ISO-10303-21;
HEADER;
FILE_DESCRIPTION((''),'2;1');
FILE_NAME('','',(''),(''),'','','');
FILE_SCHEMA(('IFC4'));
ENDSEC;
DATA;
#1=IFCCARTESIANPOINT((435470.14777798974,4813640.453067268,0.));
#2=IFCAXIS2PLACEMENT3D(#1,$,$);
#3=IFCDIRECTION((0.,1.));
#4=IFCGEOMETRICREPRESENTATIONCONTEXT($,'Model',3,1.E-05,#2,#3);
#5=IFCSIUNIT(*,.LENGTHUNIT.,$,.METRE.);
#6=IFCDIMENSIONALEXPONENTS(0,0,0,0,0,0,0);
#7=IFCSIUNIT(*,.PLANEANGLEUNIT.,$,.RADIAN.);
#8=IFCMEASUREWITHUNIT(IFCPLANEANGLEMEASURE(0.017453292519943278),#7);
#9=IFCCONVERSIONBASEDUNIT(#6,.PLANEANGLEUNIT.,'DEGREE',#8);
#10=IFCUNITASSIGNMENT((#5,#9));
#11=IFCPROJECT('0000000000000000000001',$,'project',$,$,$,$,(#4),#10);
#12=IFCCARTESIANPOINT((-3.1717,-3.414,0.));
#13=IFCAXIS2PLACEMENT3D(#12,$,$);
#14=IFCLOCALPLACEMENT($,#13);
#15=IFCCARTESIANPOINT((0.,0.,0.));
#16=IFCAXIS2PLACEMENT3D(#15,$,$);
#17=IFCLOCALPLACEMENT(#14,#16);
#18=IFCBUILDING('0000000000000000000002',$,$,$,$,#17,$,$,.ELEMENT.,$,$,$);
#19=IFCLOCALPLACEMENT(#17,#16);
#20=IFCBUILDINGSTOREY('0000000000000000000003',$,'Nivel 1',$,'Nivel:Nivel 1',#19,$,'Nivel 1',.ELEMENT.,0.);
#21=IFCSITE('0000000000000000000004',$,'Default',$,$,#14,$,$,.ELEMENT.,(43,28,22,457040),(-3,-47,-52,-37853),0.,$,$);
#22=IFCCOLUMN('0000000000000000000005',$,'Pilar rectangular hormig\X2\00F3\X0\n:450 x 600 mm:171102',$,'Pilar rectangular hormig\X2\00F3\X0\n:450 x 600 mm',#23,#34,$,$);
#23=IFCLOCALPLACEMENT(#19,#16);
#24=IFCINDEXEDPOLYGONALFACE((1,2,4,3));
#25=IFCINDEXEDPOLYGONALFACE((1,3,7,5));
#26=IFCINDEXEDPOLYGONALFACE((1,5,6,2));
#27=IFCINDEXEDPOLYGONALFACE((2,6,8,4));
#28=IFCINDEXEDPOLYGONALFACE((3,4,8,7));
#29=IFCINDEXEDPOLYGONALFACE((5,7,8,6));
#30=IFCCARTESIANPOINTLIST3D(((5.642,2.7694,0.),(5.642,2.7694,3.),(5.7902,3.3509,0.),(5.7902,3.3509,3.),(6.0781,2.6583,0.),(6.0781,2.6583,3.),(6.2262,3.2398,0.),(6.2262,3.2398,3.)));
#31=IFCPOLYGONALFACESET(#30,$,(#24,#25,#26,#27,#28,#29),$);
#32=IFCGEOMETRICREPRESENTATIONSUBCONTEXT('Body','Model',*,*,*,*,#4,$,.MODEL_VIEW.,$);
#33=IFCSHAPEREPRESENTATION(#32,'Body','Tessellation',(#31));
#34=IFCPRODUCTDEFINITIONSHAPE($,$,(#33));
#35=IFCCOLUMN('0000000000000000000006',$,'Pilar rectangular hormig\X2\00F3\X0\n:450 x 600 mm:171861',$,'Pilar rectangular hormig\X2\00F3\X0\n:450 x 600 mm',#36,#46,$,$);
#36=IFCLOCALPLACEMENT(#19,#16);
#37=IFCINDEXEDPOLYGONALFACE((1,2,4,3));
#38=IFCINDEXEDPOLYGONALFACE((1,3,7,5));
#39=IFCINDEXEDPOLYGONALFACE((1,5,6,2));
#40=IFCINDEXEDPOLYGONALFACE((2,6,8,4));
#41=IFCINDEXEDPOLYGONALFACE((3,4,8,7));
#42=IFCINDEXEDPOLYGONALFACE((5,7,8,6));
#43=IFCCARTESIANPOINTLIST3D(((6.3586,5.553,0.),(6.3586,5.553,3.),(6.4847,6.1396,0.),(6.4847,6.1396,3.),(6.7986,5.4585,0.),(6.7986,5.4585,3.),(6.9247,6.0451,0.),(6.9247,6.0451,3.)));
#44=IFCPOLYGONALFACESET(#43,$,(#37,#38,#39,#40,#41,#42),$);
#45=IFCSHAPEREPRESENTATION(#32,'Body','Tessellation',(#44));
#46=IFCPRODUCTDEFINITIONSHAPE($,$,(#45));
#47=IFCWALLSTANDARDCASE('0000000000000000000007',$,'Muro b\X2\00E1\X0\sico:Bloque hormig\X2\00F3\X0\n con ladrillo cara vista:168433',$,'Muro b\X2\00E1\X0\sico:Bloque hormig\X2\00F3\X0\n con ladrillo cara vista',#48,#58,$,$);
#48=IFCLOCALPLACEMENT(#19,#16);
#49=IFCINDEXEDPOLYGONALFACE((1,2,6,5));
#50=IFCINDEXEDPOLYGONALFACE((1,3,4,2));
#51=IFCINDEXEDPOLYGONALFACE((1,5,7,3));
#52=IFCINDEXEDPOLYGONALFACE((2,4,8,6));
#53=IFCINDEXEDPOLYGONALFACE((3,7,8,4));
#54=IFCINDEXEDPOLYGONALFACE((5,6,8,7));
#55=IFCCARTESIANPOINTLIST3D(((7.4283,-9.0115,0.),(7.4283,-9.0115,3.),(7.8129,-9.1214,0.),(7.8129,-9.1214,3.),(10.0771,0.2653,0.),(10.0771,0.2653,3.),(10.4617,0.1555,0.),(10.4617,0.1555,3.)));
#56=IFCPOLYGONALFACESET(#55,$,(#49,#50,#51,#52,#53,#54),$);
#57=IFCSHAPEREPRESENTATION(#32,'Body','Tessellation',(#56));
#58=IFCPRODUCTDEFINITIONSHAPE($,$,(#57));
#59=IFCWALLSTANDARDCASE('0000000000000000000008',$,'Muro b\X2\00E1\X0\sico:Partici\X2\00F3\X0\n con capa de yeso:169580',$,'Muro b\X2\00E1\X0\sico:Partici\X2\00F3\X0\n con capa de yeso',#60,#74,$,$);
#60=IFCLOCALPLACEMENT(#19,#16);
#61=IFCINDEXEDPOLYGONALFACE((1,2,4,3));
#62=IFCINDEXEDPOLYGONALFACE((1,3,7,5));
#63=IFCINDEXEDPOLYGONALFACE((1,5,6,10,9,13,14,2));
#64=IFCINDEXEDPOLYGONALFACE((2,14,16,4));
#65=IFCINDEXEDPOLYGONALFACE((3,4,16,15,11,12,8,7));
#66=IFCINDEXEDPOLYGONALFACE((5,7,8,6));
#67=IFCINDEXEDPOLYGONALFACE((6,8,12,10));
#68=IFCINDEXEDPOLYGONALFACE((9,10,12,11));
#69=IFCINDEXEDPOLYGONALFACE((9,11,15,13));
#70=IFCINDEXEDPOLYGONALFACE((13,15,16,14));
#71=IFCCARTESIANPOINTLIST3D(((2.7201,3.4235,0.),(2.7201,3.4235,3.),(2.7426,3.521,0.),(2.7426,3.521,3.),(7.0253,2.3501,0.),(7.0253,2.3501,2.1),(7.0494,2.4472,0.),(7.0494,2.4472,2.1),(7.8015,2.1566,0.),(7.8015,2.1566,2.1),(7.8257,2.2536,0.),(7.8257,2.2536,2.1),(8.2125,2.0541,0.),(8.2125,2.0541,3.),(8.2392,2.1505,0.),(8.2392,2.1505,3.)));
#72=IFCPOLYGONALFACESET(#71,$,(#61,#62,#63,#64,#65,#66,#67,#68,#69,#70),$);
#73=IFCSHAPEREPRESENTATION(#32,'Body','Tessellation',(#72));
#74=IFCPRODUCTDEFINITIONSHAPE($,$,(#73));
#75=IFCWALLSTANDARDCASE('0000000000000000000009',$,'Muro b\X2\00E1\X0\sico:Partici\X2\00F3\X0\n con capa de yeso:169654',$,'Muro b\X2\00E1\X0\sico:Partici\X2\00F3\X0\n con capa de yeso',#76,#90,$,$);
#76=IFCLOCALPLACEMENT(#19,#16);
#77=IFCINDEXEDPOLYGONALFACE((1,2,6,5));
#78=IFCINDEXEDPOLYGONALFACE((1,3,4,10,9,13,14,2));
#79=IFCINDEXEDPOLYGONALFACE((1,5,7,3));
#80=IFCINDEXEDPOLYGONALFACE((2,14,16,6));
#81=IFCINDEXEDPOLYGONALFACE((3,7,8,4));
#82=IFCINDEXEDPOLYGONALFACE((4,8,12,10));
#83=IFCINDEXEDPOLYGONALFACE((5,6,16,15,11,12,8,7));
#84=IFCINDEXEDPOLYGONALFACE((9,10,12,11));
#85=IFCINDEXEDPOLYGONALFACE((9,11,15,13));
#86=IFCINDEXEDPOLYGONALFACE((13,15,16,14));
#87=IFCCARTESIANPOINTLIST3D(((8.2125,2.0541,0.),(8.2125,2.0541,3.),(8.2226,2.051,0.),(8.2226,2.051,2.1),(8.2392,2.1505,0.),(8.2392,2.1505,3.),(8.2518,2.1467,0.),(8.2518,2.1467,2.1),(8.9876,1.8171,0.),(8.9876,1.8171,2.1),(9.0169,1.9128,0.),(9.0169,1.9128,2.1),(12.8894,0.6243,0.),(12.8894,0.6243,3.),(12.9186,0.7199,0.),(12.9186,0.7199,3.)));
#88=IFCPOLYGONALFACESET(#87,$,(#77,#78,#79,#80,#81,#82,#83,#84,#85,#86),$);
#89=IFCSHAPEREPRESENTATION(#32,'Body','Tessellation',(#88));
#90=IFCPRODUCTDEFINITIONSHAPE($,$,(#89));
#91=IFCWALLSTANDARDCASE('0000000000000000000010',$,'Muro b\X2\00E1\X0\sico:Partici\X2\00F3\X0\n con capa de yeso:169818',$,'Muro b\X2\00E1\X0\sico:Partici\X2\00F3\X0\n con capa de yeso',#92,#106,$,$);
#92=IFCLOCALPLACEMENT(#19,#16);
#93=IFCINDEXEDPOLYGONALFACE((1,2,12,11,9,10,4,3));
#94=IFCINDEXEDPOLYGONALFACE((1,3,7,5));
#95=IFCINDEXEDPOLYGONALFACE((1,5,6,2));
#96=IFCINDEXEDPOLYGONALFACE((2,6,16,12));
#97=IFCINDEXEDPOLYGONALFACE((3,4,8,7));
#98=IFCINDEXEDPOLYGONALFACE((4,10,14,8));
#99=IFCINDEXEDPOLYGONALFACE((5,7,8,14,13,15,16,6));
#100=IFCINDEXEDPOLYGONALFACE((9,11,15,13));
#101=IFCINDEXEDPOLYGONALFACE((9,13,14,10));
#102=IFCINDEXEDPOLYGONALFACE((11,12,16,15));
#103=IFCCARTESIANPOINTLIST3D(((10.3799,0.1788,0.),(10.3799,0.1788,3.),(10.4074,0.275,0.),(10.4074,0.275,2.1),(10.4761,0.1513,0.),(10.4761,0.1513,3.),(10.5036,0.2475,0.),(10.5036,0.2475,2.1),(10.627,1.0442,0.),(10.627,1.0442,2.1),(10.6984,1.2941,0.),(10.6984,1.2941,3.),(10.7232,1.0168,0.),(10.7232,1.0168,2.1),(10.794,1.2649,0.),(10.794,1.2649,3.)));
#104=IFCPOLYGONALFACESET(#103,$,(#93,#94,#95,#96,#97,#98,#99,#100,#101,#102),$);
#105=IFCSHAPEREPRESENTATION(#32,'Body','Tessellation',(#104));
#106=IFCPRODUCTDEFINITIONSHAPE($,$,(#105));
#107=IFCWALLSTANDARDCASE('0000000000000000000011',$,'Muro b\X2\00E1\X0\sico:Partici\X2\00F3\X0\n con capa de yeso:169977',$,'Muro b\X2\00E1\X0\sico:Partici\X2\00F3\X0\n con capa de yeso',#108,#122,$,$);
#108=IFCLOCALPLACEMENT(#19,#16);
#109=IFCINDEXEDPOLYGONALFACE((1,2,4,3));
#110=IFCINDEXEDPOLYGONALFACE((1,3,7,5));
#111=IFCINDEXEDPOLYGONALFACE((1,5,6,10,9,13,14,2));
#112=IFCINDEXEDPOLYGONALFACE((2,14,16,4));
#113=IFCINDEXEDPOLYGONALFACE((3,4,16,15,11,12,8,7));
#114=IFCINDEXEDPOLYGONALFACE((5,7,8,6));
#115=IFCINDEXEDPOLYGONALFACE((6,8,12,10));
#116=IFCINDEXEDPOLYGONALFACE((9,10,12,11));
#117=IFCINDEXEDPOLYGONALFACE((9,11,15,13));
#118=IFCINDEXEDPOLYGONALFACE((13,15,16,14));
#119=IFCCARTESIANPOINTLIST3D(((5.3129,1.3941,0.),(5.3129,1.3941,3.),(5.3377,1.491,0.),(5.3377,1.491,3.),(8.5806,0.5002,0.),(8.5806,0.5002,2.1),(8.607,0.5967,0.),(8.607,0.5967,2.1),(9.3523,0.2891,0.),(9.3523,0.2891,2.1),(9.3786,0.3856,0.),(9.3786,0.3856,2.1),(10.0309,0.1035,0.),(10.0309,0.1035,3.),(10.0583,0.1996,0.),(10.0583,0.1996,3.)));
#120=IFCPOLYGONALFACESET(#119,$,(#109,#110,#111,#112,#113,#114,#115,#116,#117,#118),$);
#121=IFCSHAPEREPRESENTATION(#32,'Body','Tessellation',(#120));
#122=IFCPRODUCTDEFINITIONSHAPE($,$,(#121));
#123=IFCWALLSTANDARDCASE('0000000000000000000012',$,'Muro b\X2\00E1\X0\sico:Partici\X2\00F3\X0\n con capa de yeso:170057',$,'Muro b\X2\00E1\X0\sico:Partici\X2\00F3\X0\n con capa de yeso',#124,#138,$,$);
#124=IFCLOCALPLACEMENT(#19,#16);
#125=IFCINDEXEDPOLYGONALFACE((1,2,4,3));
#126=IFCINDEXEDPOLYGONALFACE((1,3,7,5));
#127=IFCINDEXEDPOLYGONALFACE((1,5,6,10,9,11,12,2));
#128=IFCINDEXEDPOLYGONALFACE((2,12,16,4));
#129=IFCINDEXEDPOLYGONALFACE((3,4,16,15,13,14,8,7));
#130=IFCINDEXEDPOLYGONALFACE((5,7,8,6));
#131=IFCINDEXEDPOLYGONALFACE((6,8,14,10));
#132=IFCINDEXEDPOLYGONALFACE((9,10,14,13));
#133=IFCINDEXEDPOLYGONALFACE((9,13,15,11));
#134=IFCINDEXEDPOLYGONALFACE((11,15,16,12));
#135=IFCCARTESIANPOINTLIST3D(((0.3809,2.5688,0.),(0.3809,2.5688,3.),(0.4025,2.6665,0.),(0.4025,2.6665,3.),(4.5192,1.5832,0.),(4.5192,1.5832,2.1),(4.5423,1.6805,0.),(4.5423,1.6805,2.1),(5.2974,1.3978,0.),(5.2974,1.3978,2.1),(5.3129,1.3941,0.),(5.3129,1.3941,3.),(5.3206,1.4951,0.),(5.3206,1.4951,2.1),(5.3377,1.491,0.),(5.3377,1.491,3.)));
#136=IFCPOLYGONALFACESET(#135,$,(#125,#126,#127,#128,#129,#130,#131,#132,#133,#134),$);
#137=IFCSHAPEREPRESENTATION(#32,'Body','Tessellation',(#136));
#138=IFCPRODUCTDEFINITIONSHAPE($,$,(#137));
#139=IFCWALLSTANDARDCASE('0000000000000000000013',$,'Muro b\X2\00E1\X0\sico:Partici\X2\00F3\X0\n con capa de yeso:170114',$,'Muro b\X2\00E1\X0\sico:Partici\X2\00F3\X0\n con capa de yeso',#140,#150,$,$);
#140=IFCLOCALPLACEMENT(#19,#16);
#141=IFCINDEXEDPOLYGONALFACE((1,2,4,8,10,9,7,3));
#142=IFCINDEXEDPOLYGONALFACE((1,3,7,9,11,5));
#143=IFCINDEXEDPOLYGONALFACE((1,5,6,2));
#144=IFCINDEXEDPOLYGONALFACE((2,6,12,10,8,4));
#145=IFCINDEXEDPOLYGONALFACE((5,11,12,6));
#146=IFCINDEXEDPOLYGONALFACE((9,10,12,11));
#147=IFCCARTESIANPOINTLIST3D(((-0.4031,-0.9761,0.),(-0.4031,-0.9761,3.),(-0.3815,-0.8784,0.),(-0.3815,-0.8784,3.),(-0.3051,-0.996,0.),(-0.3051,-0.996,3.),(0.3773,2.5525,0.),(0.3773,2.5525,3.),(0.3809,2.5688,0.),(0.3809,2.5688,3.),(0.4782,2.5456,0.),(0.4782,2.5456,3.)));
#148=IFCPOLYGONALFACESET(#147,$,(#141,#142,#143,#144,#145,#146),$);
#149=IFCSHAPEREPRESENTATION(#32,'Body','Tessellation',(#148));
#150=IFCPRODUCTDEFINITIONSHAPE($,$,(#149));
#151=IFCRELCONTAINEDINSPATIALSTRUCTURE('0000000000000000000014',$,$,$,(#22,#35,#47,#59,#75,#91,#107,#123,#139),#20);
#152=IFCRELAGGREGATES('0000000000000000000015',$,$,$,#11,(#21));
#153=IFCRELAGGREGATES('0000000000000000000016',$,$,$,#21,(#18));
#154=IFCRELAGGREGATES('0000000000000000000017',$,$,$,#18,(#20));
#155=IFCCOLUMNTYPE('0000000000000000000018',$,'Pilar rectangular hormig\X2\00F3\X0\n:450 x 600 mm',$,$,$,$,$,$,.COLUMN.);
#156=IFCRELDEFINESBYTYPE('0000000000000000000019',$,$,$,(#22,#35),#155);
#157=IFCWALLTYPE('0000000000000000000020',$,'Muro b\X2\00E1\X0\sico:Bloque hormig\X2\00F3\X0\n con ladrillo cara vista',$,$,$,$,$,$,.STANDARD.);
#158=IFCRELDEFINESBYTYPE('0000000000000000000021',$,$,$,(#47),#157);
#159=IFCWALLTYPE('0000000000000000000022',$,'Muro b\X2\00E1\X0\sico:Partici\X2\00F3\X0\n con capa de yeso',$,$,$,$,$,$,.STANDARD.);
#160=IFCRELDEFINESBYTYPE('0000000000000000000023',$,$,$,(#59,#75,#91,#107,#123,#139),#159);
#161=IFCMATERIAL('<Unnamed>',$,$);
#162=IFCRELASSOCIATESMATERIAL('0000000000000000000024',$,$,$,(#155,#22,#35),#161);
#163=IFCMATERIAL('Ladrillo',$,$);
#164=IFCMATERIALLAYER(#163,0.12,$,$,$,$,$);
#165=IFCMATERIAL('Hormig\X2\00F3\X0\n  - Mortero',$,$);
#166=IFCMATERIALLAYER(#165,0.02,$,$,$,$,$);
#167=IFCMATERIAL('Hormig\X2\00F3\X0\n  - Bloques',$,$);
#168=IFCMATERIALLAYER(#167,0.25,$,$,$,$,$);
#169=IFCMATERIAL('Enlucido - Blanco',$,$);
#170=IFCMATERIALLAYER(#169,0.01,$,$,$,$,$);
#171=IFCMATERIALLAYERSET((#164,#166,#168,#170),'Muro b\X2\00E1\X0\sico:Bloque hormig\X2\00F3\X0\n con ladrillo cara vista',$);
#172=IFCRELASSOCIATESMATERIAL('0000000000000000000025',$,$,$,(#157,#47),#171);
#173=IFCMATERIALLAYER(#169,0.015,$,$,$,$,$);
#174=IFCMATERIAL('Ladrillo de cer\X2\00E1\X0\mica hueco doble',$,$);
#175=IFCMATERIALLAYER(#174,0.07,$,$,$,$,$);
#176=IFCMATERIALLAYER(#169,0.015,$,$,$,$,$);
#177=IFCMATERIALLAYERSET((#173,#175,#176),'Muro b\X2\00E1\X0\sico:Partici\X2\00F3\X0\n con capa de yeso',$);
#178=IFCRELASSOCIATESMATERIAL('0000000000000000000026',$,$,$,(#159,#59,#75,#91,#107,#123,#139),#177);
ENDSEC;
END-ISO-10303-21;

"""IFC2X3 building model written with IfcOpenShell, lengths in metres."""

from ifc_helpers import new_model, entity, si_unit, converted_unit, direction, frame, frame_2d, origin, origin_2d_with_axis, place, context, subcontext, project, spatial, polyline, rectangle, outline, extrude, source, transform, mapped, material, layer, layer_set, layer_usage, type_object, type_shapes, element, save


model = new_model("IFC2X3")

# Units and contexts
model_context = context("Model", 3, precision=1e-05, world=frame((435470.14777798974, 4813640.453067268, 0.0)), true_north=direction((0.0, 1.0)))
body_context = subcontext(model_context, "Body", "Model", "MODEL_VIEW")
ifc_project = project(units=[si_unit("LENGTHUNIT", "METRE"), converted_unit("PLANEANGLEUNIT", "DEGREE", entity("IfcPlaneAngleMeasure", 0.017453292519943278), si_unit("PLANEANGLEUNIT", "RADIAN"), dimensions=[0, 0, 0, 0, 0, 0, 0])], contexts=[model_context])

# Site, building, storey
site_placement = place(None, frame((-3.1717, -3.414, 0.0)))
site = spatial("IfcSite", under=ifc_project, at=site_placement, Name="Default", CompositionType="ELEMENT", RefLatitude=(43, 28, 22, 457040), RefLongitude=(-3, -47, -52, -37853), RefElevation=0.0)
building_placement = place(site_placement, origin())
building = spatial("IfcBuilding", under=site, at=building_placement, CompositionType="ELEMENT")
storey_placement = place(building_placement, origin())
storey = spatial("IfcBuildingStorey", under=building, at=storey_placement, Name="Nivel 1", ObjectType="Nivel:Nivel 1", LongName="Nivel 1", CompositionType="ELEMENT", Elevation=0.0)

# Columns
ifc_material_1 = material(Name="<Unnamed>")
column_type = type_object("IfcColumnType", Name="Pilar rectangular hormigón:450 x 600 mm", PredefinedType="COLUMN", material=ifc_material_1)
shared_shape_1 = source(origin(), body_context, "Body", "SweptSolid", [
    extrude(rectangle(XDim=0.45, YDim=0.6, at=origin_2d_with_axis()), frame((0.0, 0.0, 0.0), z_axis=(0.0, 0.0, 1.0), x_axis=(-1.0, 0.0, 0.0)), (0.0, 0.0, 1.0), 3.0),
])
type_shapes(column_type, [shared_shape_1])
for number, where, z_axis, x_axis, name in (
    (1, (5.9341, 3.0046, 0.0), (0.0, 0.0, 1.0), (0.969039, -0.246908, 0.0), "Pilar rectangular hormigón:450 x 600 mm:171102"),
    (2, (6.6416, 5.799, 0.0), (0.0, 0.0, 1.0), (0.977667, -0.210159, 0.0), "Pilar rectangular hormigón:450 x 600 mm:171861"),
):
    element("IfcColumn", number, at=place(storey_placement, frame(where, z_axis=z_axis, x_axis=x_axis)), inside=storey, type_object=column_type, material=ifc_material_1, Name=name, ObjectType="Pilar rectangular hormigón:450 x 600 mm", context=body_context, shape_type="MappedRepresentation", body=[
        mapped(shared_shape_1, transform((0.0, 0.0, 0.0), scale=1.0)),
    ])

# Shared definitions
ifc_material_2 = material(Name="Enlucido - Blanco")

# Wall
ifc_material_3 = material(Name="Ladrillo")
ifc_layer_1 = layer(ifc_material_3, 0.12)
ifc_material_4 = material(Name="Hormigón  - Mortero")
ifc_layer_2 = layer(ifc_material_4, 0.02)
ifc_material_5 = material(Name="Hormigón  - Bloques")
ifc_layer_3 = layer(ifc_material_5, 0.25)
ifc_layer_4 = layer(ifc_material_2, 0.01)
ifc_layer_set_1 = layer_set([ifc_layer_1, ifc_layer_2, ifc_layer_3, ifc_layer_4], Name="Muro básico:Bloque hormigón con ladrillo cara vista")
wall_type_1 = type_object("IfcWallType", Name="Muro básico:Bloque hormigón con ladrillo cara vista", PredefinedType="STANDARD", material=ifc_layer_set_1)
ifc_layer_usage_1 = layer_usage(ifc_layer_set_1, "AXIS2", "NEGATIVE", 0.2)
wall_1_placement = place(storey_placement, frame((10.2694, 0.2104, 0.0), z_axis=(0.0, 0.0, 1.0), x_axis=(-0.274552, -0.961572, 0.0)))
element("IfcWallStandardCase", 3, at=wall_1_placement, inside=storey, type_object=wall_type_1, material=ifc_layer_usage_1, Name="Muro básico:Bloque hormigón con ladrillo cara vista:168433", ObjectType="Muro básico:Bloque hormigón con ladrillo cara vista", context=body_context, shape_type="SweptSolid", body=[
    extrude(rectangle(XDim=9.6476, YDim=0.4, at=frame_2d((4.8238, 0.0), x_axis=(-1.0, 0.0))), origin(), (0.0, 0.0, 1.0), 3.0),
])

# Walls, openings
ifc_layer_5 = layer(ifc_material_2, 0.015)
ifc_material_6 = material(Name="Ladrillo de cerámica hueco doble")
ifc_layer_6 = layer(ifc_material_6, 0.07)
ifc_layer_7 = layer(ifc_material_2, 0.015)
ifc_layer_set_2 = layer_set([ifc_layer_5, ifc_layer_6, ifc_layer_7], Name="Muro básico:Partición con capa de yeso")
ifc_layer_usage_2 = layer_usage(ifc_layer_set_2, "AXIS2", "NEGATIVE", 0.05)
wall_type_2 = type_object("IfcWallType", Name="Muro básico:Partición con capa de yeso", PredefinedType="STANDARD", material=ifc_layer_set_2)
wall_2_placement = place(storey_placement, frame((2.7305, 3.4725, 0.0), z_axis=(0.0, 0.0, 1.0), x_axis=(0.970296, -0.241922, 0.0)))
wall_2 = element("IfcWallStandardCase", 4, at=wall_2_placement, inside=storey, type_object=wall_type_2, material=ifc_layer_usage_2, Name="Muro básico:Partición con capa de yeso:169580", ObjectType="Muro básico:Partición con capa de yeso", context=body_context, shape_type="SweptSolid", body=[
    extrude(outline(polyline([(0.0018, -0.05), (5.6622, -0.05), (5.6648, 0.05), (5.4827, 0.05), (5.3826, 0.05), (0.4422, 0.05), (0.3422, 0.05), (0.0, 0.05), (0.0018, -0.05)])), origin(), (0.0, 0.0, 1.0), 3.0),
])
opening_1_placement = place(wall_2_placement, frame((4.4387, -0.05, 0.0)))
element("IfcOpeningElement", 5, at=opening_1_placement, cuts=wall_2, ObjectType="Opening", context=body_context, shape_type="SweptSolid", body=[
    extrude(rectangle(XDim=2.1, YDim=0.8, at=frame_2d((1.05, 0.4), x_axis=(1.0, 0.0))), frame((0.0, 0.0, 0.0), z_axis=(0.0, 1.0, 0.0), x_axis=(0.0, 0.0, 1.0)), (0.0, 0.0, 1.0), 0.1),
])
ifc_layer_usage_3 = layer_usage(ifc_layer_set_2, "AXIS2", "NEGATIVE", 0.05)
wall_3_placement = place(storey_placement, frame((8.2246, 2.1027, 0.0), z_axis=(0.0, 0.0, 1.0), x_axis=(0.956305, -0.292372, 0.0)))
wall_3 = element("IfcWallStandardCase", 6, at=wall_3_placement, inside=storey, type_object=wall_type_2, material=ifc_layer_usage_3, Name="Muro básico:Partición con capa de yeso:169654", ObjectType="Muro básico:Partición con capa de yeso", context=body_context, shape_type="SweptSolid", body=[
    extrude(outline(polyline([(0.0026, -0.05), (2.6022, -0.05), (2.7022, -0.05), (4.8932, -0.05), (4.8932, 0.05), (0.0, 0.05), (0.0026, -0.05)])), origin(), (0.0, 0.0, 1.0), 3.0),
])
opening_2_placement = place(wall_3_placement, frame((0.0132, -0.05, 0.0)))
element("IfcOpeningElement", 7, at=opening_2_placement, cuts=wall_3, ObjectType="Opening", context=body_context, shape_type="SweptSolid", body=[
    extrude(rectangle(XDim=2.1, YDim=0.8, at=frame_2d((1.05, 0.4), x_axis=(1.0, 0.0))), frame((0.0, 0.0, 0.0), z_axis=(0.0, 1.0, 0.0), x_axis=(0.0, 0.0, 1.0)), (0.0, 0.0, 1.0), 0.1),
])
ifc_layer_usage_4 = layer_usage(ifc_layer_set_2, "AXIS2", "NEGATIVE", 0.05)
wall_4_placement = place(storey_placement, frame((10.7465, 1.2804, 0.0), z_axis=(0.0, 0.0, 1.0), x_axis=(-0.274552, -0.961572, 0.0)))
wall_4 = element("IfcWallStandardCase", 8, at=wall_4_placement, inside=storey, type_object=wall_type_2, material=ifc_layer_usage_4, Name="Muro básico:Partición con capa de yeso:169818", ObjectType="Muro básico:Partición con capa de yeso", context=body_context, shape_type="SweptSolid", body=[
    extrude(outline(polyline([(0.0, -0.05), (1.1599, -0.05), (1.1599, 0.035), (1.1599, 0.05), (0.0019, 0.05), (0.0, -0.05)])), origin(), (0.0, 0.0, 1.0), 3.0),
])
opening_3_placement = place(wall_4_placement, frame((0.2599, -0.05, 0.0)))
element("IfcOpeningElement", 9, at=opening_3_placement, cuts=wall_4, ObjectType="Opening", context=body_context, shape_type="SweptSolid", body=[
    extrude(rectangle(XDim=2.1, YDim=0.8, at=frame_2d((1.05, 0.4), x_axis=(1.0, 0.0))), frame((0.0, 0.0, 0.0), z_axis=(0.0, 1.0, 0.0), x_axis=(0.0, 0.0, 1.0)), (0.0, 0.0, 1.0), 0.1),
])
ifc_layer_usage_5 = layer_usage(ifc_layer_set_2, "AXIS2", "POSITIVE", -0.05)
wall_5_placement = place(storey_placement, frame((10.0451, 0.1514, 0.0), z_axis=(0.0, 0.0, 1.0), x_axis=(-0.964559, 0.263866, 0.0)))
wall_5 = element("IfcWallStandardCase", 10, at=wall_5_placement, inside=storey, type_object=wall_type_2, material=ifc_layer_usage_5, Name="Muro básico:Partición con capa de yeso:169977", ObjectType="Muro básico:Partición con capa de yeso", context=body_context, shape_type="SweptSolid", body=[
    extrude(outline(polyline([(0.0, -0.05), (4.8941, -0.05), (4.8925, 0.05), (0.0011, 0.05), (0.0, -0.05)])), origin(), (0.0, 0.0, 1.0), 3.0),
])
opening_4_placement = place(wall_5_placement, frame((0.7046, -0.05, 0.0)))
element("IfcOpeningElement", 11, at=opening_4_placement, cuts=wall_5, ObjectType="Opening", context=body_context, shape_type="SweptSolid", body=[
    extrude(rectangle(XDim=2.1, YDim=0.8, at=frame_2d((1.05, 0.4), x_axis=(1.0, 0.0))), frame((0.0, 0.0, 0.0), z_axis=(0.0, 1.0, 0.0), x_axis=(0.0, 0.0, 1.0)), (0.0, 0.0, 1.0), 0.1),
])
ifc_layer_usage_6 = layer_usage(ifc_layer_set_2, "AXIS2", "POSITIVE", -0.05)
wall_6_placement = place(storey_placement, frame((5.3261, 1.4424, 0.0), z_axis=(0.0, 0.0, 1.0), x_axis=(-0.972789, 0.231693, 0.0)))
wall_6 = element("IfcWallStandardCase", 12, at=wall_6_placement, inside=storey, type_object=wall_type_2, material=ifc_layer_usage_6, Name="Muro básico:Partición con capa de yeso:170057", ObjectType="Muro básico:Partición con capa de yeso", context=body_context, shape_type="SweptSolid", body=[
    extrude(outline(polyline([(0.0, -0.05), (5.0732, -0.05), (5.0729, -0.0333), (5.0716, 0.05), (4.9716, 0.05), (0.0017, 0.05), (0.0, -0.05)])), origin(), (0.0, 0.0, 1.0), 3.0),
])
opening_5_placement = place(wall_6_placement, frame((0.0176, -0.05, 0.0)))
element("IfcOpeningElement", 13, at=opening_5_placement, cuts=wall_6, ObjectType="Opening", context=body_context, shape_type="SweptSolid", body=[
    extrude(rectangle(XDim=2.1, YDim=0.8, at=frame_2d((1.05, 0.4), x_axis=(1.0, 0.0))), frame((0.0, 0.0, 0.0), z_axis=(0.0, 1.0, 0.0), x_axis=(0.0, 0.0, 1.0)), (0.0, 0.0, 1.0), 0.1),
])

# Wall
ifc_layer_usage_7 = layer_usage(ifc_layer_set_2, "AXIS2", "POSITIVE", -0.05)
wall_7_placement = place(storey_placement, frame((0.4297, 2.558, 0.0), z_axis=(0.0, 0.0, 1.0), x_axis=(-0.215934, -0.976408, 0.0)))
element("IfcWallStandardCase", 14, at=wall_7_placement, inside=storey, type_object=wall_type_2, material=ifc_layer_usage_7, Name="Muro básico:Partición con capa de yeso:170114", ObjectType="Muro básico:Partición con capa de yeso", context=body_context, shape_type="SweptSolid", body=[
    extrude(outline(polyline([(3.6305, -0.05), (3.6289, 0.05), (0.0016, 0.05), (0.0, -0.05), (0.0167, -0.05), (3.5305, -0.05), (3.6305, -0.05)])), origin(), (0.0, 0.0, 1.0), 3.0),
])

save(model, "model.ifc")
